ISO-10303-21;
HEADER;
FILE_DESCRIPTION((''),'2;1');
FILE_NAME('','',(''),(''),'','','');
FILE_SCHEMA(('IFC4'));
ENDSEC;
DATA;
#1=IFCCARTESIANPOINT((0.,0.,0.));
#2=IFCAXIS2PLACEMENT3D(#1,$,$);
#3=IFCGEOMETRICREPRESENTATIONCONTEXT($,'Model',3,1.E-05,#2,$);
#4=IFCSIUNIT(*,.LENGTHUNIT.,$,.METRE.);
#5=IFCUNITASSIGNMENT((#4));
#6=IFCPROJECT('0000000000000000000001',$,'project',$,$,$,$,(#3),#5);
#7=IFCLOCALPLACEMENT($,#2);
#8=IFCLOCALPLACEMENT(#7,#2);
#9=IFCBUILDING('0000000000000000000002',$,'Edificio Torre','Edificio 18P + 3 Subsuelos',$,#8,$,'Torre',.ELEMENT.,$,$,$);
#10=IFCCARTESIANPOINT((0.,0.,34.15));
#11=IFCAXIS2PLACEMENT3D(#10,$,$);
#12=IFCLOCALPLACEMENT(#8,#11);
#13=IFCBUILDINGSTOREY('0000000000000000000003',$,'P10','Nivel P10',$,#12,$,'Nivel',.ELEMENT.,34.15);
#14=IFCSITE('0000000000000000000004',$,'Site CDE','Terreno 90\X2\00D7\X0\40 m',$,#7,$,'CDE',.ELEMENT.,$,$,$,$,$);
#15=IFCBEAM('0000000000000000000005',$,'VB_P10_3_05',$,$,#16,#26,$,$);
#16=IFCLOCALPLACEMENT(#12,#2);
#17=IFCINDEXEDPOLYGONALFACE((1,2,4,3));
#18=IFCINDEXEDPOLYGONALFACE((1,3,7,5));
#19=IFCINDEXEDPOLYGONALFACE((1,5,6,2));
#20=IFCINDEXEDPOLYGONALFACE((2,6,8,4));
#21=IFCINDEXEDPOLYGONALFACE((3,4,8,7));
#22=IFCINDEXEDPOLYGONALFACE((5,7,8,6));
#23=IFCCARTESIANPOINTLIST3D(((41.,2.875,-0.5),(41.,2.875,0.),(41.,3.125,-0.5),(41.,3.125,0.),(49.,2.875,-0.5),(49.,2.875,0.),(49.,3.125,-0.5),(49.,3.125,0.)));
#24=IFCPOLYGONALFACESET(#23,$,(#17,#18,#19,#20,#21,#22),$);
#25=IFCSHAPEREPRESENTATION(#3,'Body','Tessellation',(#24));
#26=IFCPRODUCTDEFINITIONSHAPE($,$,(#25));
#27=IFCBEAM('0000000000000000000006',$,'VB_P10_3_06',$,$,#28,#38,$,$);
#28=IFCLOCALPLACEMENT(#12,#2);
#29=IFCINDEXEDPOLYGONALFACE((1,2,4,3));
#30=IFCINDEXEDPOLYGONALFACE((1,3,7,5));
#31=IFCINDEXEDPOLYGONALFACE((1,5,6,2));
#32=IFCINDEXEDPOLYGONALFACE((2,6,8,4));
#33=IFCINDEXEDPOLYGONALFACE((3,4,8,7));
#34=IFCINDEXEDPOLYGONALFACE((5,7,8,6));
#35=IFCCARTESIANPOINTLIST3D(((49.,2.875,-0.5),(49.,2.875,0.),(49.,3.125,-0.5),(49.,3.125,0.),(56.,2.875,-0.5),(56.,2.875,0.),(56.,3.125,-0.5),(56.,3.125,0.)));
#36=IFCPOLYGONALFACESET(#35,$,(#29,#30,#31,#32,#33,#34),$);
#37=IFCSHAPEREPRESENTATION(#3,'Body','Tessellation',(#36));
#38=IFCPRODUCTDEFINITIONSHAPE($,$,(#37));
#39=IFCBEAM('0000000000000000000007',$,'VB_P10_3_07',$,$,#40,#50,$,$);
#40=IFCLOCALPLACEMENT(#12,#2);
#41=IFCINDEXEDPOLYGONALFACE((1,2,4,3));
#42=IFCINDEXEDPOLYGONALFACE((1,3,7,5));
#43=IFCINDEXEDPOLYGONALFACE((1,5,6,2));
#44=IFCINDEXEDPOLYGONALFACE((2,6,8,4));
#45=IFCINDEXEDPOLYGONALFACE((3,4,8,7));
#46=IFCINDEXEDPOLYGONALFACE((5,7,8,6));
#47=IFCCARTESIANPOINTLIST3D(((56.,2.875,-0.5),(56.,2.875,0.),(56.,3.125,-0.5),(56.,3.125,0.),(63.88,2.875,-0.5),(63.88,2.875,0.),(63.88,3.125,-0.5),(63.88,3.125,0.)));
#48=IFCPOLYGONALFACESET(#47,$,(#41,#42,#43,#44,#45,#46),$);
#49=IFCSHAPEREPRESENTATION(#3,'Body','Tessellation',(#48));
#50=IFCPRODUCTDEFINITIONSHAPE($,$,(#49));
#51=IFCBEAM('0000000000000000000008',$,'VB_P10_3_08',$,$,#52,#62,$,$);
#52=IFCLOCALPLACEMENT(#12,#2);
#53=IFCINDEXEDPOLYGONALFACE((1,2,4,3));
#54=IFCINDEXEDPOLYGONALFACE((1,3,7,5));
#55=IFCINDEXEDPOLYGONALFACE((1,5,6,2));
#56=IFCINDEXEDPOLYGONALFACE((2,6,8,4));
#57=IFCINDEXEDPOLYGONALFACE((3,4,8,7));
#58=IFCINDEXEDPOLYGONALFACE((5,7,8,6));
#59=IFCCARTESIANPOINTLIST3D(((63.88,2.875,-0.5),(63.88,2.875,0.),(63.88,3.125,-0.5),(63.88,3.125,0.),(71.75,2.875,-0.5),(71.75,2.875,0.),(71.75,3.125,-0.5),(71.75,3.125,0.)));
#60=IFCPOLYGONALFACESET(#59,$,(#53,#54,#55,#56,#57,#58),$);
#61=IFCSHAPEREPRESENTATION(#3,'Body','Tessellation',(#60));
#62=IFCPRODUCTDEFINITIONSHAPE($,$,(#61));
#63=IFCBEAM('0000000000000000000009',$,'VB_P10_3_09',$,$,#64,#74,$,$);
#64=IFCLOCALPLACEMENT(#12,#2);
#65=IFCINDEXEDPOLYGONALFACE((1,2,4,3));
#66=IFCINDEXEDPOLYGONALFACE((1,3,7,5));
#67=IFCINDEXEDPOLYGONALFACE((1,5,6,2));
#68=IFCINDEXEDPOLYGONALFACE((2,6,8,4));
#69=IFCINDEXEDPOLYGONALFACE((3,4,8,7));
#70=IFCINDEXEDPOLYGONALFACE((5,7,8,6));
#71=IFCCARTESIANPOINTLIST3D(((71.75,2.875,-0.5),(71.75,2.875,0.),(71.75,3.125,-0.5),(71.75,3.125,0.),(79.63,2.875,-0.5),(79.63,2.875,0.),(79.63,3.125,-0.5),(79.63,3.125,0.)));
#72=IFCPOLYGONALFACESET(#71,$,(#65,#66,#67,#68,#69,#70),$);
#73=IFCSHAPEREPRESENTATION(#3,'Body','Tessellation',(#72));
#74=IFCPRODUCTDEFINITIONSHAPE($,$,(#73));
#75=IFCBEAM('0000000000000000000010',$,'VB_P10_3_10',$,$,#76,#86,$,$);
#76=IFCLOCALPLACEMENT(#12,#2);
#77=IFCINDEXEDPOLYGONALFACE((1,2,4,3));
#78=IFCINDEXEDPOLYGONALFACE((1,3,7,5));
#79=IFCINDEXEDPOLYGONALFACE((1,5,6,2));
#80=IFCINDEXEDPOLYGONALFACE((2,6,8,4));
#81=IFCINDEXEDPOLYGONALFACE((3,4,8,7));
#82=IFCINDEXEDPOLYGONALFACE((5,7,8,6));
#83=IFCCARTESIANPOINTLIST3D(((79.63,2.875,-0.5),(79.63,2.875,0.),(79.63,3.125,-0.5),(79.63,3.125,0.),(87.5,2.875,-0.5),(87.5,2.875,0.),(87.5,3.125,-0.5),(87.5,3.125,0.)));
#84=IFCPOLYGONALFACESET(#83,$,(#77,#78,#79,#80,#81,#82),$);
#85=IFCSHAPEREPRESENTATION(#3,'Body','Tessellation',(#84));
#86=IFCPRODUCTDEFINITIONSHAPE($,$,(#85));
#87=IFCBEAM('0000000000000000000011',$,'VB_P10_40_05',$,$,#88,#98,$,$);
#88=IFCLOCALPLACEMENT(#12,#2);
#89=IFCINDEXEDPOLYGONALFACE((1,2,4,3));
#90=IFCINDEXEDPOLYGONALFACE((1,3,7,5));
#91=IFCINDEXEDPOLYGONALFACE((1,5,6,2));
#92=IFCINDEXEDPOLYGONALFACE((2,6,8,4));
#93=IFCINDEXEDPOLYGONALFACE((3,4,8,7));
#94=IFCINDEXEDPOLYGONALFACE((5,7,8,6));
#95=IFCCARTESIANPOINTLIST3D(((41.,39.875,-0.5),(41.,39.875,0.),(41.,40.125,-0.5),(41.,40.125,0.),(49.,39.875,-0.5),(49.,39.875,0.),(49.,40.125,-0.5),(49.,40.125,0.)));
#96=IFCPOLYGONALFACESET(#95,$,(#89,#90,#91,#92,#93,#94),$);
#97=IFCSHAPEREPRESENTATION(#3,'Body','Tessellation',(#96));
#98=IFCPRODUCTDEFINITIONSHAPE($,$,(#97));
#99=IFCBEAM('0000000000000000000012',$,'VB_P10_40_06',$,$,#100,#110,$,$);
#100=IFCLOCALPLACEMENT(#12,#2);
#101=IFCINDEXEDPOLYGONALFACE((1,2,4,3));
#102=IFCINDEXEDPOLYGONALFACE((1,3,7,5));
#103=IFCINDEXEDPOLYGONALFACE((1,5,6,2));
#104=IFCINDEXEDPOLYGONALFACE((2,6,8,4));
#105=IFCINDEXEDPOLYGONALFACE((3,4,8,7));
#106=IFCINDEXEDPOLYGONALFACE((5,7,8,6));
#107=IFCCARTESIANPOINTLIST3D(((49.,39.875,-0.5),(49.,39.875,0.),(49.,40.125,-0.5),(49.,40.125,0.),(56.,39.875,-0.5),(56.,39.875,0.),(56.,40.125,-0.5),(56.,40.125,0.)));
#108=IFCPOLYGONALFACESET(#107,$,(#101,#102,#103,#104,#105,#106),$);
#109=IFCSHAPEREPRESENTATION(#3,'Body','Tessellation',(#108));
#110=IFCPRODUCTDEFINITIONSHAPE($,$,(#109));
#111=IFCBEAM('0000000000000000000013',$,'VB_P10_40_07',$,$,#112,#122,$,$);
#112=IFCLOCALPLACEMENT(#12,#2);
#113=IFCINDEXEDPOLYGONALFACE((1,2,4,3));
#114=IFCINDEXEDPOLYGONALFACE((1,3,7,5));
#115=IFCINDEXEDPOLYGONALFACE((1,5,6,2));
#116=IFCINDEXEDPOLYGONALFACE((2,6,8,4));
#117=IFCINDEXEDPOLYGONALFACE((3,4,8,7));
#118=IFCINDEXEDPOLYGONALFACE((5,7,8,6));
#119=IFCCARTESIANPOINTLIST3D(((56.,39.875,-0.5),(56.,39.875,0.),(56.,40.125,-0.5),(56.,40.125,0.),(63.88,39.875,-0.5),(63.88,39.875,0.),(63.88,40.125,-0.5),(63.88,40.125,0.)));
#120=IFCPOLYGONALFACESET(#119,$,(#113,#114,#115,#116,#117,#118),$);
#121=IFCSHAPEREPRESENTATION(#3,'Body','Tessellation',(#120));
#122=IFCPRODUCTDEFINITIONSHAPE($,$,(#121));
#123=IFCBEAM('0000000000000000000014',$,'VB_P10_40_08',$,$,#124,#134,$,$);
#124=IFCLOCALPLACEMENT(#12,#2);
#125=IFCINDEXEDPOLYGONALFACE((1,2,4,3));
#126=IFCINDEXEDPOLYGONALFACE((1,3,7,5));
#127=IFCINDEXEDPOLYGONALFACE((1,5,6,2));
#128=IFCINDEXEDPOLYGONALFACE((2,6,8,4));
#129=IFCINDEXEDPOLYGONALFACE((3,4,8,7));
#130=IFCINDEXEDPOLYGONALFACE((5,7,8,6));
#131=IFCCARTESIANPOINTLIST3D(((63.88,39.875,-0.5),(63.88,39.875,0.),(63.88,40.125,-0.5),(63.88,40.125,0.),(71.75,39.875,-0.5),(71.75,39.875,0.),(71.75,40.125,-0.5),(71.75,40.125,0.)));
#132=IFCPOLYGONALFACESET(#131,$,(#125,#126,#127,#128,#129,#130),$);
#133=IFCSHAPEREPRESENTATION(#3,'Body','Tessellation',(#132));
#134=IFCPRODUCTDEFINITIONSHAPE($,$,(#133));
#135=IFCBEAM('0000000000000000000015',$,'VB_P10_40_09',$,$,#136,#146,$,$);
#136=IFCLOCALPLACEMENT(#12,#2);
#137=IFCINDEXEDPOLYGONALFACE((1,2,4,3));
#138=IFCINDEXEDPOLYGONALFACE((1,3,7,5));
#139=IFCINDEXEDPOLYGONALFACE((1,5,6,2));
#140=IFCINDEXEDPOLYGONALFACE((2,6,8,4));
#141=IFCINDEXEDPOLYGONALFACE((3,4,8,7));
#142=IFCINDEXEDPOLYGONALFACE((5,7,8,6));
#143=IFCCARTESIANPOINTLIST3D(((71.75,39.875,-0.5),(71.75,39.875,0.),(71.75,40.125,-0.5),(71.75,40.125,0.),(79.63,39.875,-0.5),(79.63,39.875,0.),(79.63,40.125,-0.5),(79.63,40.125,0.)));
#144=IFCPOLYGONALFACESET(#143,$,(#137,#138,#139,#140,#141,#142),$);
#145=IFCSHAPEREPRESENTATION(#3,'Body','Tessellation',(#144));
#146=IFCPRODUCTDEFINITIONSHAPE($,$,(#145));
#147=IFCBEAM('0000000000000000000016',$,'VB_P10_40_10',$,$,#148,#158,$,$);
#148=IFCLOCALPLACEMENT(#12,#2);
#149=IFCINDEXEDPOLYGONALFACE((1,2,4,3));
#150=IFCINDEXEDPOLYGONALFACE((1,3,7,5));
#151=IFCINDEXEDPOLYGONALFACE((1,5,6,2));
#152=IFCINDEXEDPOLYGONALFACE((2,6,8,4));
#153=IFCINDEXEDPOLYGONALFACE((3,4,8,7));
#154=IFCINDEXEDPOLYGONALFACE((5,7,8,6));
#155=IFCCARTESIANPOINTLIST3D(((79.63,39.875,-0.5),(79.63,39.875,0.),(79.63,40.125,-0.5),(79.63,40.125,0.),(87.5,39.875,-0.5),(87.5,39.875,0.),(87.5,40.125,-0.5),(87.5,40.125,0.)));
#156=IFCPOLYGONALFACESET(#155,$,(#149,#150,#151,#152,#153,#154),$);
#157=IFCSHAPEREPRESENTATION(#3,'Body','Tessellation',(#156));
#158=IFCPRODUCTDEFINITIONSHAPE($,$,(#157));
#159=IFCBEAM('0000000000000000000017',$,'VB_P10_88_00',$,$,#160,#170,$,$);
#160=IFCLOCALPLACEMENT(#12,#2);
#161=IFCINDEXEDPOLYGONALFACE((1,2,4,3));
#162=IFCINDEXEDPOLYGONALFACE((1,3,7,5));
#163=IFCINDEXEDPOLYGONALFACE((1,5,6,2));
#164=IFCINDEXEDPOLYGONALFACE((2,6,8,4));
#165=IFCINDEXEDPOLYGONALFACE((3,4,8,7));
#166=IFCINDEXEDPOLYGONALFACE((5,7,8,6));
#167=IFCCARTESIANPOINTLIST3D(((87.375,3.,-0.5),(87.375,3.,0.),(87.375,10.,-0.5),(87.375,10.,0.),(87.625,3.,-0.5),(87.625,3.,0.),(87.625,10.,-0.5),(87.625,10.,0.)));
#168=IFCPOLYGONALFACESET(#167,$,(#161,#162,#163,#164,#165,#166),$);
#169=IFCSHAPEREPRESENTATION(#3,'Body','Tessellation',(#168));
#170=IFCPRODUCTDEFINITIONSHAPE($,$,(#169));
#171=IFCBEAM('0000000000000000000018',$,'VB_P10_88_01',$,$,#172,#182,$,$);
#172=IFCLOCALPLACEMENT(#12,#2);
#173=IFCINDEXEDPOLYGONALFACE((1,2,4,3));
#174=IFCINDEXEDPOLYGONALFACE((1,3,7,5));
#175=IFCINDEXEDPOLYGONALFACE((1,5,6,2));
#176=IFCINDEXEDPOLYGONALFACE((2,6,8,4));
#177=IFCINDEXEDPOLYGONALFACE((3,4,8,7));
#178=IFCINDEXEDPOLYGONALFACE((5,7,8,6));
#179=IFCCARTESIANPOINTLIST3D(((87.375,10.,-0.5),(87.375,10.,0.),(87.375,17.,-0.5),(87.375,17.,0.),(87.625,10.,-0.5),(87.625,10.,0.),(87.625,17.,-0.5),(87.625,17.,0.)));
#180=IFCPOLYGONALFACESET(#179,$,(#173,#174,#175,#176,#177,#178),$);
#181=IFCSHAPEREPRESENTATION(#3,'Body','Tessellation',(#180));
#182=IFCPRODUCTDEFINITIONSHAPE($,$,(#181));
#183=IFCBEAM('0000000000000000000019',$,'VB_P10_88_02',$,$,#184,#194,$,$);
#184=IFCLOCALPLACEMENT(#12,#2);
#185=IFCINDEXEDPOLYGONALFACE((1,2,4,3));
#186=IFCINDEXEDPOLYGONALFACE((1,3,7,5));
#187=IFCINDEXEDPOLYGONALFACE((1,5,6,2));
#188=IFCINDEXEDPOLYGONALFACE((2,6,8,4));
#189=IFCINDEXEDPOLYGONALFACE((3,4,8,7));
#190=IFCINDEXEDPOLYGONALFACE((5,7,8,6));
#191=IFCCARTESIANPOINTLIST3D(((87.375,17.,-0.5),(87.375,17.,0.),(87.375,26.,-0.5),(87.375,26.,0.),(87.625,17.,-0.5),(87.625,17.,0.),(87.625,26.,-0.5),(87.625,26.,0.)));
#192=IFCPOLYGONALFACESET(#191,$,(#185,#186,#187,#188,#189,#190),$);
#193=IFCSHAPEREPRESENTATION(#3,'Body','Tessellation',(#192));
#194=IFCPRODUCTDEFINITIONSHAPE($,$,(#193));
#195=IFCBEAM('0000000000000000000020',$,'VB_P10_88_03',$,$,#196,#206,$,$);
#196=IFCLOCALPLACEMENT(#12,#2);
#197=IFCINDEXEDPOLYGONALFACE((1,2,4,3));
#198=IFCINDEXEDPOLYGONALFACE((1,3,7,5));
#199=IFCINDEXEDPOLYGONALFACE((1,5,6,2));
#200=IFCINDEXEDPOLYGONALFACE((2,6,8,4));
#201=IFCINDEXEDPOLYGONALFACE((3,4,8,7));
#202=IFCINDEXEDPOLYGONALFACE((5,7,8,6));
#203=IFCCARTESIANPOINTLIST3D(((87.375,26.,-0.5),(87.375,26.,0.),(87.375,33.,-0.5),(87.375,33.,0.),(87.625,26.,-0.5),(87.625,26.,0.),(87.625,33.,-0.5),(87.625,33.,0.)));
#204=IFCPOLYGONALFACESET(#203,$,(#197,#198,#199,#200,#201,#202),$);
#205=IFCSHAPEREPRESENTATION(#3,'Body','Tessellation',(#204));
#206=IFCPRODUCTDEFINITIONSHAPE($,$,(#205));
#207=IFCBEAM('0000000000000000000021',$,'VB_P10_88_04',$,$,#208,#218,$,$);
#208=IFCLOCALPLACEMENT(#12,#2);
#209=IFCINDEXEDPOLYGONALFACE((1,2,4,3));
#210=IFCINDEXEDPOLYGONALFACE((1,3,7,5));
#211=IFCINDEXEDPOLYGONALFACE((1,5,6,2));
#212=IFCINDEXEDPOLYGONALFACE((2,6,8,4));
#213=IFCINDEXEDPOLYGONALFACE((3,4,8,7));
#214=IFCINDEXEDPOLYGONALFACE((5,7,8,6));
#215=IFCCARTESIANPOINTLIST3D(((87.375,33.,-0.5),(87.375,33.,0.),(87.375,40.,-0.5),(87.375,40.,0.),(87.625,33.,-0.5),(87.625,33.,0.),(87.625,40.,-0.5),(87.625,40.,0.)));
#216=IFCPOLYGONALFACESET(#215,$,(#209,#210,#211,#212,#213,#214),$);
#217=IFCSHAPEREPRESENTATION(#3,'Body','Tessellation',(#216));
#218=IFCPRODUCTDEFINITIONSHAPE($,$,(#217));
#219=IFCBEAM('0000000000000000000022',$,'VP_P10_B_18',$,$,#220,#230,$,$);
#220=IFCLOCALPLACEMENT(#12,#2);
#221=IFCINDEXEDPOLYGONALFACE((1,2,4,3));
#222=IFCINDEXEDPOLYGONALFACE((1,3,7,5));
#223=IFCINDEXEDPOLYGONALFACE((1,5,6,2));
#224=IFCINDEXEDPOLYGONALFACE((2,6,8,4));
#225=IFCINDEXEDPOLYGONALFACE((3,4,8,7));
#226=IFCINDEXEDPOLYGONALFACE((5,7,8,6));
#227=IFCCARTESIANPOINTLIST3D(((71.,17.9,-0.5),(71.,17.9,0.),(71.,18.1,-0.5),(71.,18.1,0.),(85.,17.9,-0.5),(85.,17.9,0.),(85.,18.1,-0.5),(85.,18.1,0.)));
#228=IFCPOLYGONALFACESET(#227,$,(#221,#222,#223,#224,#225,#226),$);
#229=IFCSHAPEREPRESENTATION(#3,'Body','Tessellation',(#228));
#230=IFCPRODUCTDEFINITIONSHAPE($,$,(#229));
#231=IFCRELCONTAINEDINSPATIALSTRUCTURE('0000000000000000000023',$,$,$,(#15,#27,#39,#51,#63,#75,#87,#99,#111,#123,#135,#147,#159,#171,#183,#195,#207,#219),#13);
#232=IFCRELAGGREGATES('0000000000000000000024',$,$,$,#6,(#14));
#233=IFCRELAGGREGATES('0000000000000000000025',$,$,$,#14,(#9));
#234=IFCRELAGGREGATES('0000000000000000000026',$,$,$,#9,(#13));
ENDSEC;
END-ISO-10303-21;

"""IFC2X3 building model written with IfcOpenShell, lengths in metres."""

from ifc_helpers import new_model, si_unit, frame, origin, origin_2d, place, context, project, spatial, rectangle, extrude, element, save


model = new_model("IFC2X3")

# Units and contexts
model_context = context("Model", 3, precision=1e-05, world=origin())
ifc_project = project(units=[si_unit("LENGTHUNIT", "METRE")], contexts=[model_context])

# Site, building, storey
site_placement = place(None, origin())
site = spatial("IfcSite", under=ifc_project, at=site_placement, Name="Site CDE", Description="Terreno 90×40 m", LongName="CDE", CompositionType="ELEMENT")
building_placement = place(site_placement, origin())
building = spatial("IfcBuilding", under=site, at=building_placement, Name="Edificio Torre", Description="Edificio 18P + 3 Subsuelos", LongName="Torre", CompositionType="ELEMENT")
storey_placement = place(building_placement, frame((0.0, 0.0, 34.15)))
storey = spatial("IfcBuildingStorey", under=building, at=storey_placement, Name="P10", Description="Nivel P10", LongName="Nivel", CompositionType="ELEMENT", Elevation=34.15)

# Beams
beam_1_placement = place(storey_placement, frame((45.0, 3.0, -0.5)))
element("IfcBeam", 1, at=beam_1_placement, inside=storey, Name="VB_P10_3_05", context=model_context, shape_type="SweptSolid", body=[
    extrude(rectangle(XDim=8.0, YDim=0.25, at=origin_2d()), origin(), (0.0, 0.0, 1.0), 0.5),
])
beam_2_placement = place(storey_placement, frame((52.5, 3.0, -0.5)))
element("IfcBeam", 2, at=beam_2_placement, inside=storey, Name="VB_P10_3_06", context=model_context, shape_type="SweptSolid", body=[
    extrude(rectangle(XDim=7.0, YDim=0.25, at=origin_2d()), origin(), (0.0, 0.0, 1.0), 0.5),
])
beam_3_placement = place(storey_placement, frame((59.94, 3.0, -0.5)))
element("IfcBeam", 3, at=beam_3_placement, inside=storey, Name="VB_P10_3_07", context=model_context, shape_type="SweptSolid", body=[
    extrude(rectangle(XDim=7.88, YDim=0.25, at=origin_2d()), origin(), (0.0, 0.0, 1.0), 0.5),
])
beam_4_placement = place(storey_placement, frame((67.815, 3.0, -0.5)))
element("IfcBeam", 4, at=beam_4_placement, inside=storey, Name="VB_P10_3_08", context=model_context, shape_type="SweptSolid", body=[
    extrude(rectangle(XDim=7.87, YDim=0.25, at=origin_2d()), origin(), (0.0, 0.0, 1.0), 0.5),
])
beam_5_placement = place(storey_placement, frame((75.69, 3.0, -0.5)))
element("IfcBeam", 5, at=beam_5_placement, inside=storey, Name="VB_P10_3_09", context=model_context, shape_type="SweptSolid", body=[
    extrude(rectangle(XDim=7.88, YDim=0.25, at=origin_2d()), origin(), (0.0, 0.0, 1.0), 0.5),
])
beam_6_placement = place(storey_placement, frame((83.565, 3.0, -0.5)))
element("IfcBeam", 6, at=beam_6_placement, inside=storey, Name="VB_P10_3_10", context=model_context, shape_type="SweptSolid", body=[
    extrude(rectangle(XDim=7.87, YDim=0.25, at=origin_2d()), origin(), (0.0, 0.0, 1.0), 0.5),
])
beam_7_placement = place(storey_placement, frame((45.0, 40.0, -0.5)))
element("IfcBeam", 7, at=beam_7_placement, inside=storey, Name="VB_P10_40_05", context=model_context, shape_type="SweptSolid", body=[
    extrude(rectangle(XDim=8.0, YDim=0.25, at=origin_2d()), origin(), (0.0, 0.0, 1.0), 0.5),
])
beam_8_placement = place(storey_placement, frame((52.5, 40.0, -0.5)))
element("IfcBeam", 8, at=beam_8_placement, inside=storey, Name="VB_P10_40_06", context=model_context, shape_type="SweptSolid", body=[
    extrude(rectangle(XDim=7.0, YDim=0.25, at=origin_2d()), origin(), (0.0, 0.0, 1.0), 0.5),
])
beam_9_placement = place(storey_placement, frame((59.94, 40.0, -0.5)))
element("IfcBeam", 9, at=beam_9_placement, inside=storey, Name="VB_P10_40_07", context=model_context, shape_type="SweptSolid", body=[
    extrude(rectangle(XDim=7.88, YDim=0.25, at=origin_2d()), origin(), (0.0, 0.0, 1.0), 0.5),
])
beam_10_placement = place(storey_placement, frame((67.815, 40.0, -0.5)))
element("IfcBeam", 10, at=beam_10_placement, inside=storey, Name="VB_P10_40_08", context=model_context, shape_type="SweptSolid", body=[
    extrude(rectangle(XDim=7.87, YDim=0.25, at=origin_2d()), origin(), (0.0, 0.0, 1.0), 0.5),
])
beam_11_placement = place(storey_placement, frame((75.69, 40.0, -0.5)))
element("IfcBeam", 11, at=beam_11_placement, inside=storey, Name="VB_P10_40_09", context=model_context, shape_type="SweptSolid", body=[
    extrude(rectangle(XDim=7.88, YDim=0.25, at=origin_2d()), origin(), (0.0, 0.0, 1.0), 0.5),
])
beam_12_placement = place(storey_placement, frame((83.565, 40.0, -0.5)))
element("IfcBeam", 12, at=beam_12_placement, inside=storey, Name="VB_P10_40_10", context=model_context, shape_type="SweptSolid", body=[
    extrude(rectangle(XDim=7.87, YDim=0.25, at=origin_2d()), origin(), (0.0, 0.0, 1.0), 0.5),
])
for number, where, name in (
    (13, (87.5, 6.5, -0.5), "VB_P10_88_00"),
    (14, (87.5, 13.5, -0.5), "VB_P10_88_01"),
):
    element("IfcBeam", number, at=place(storey_placement, frame(where)), inside=storey, Name=name, context=model_context, shape_type="SweptSolid", body=[
        extrude(rectangle(XDim=0.25, YDim=7.0, at=origin_2d()), origin(), (0.0, 0.0, 1.0), 0.5),
    ])
beam_13_placement = place(storey_placement, frame((87.5, 21.5, -0.5)))
element("IfcBeam", 15, at=beam_13_placement, inside=storey, Name="VB_P10_88_02", context=model_context, shape_type="SweptSolid", body=[
    extrude(rectangle(XDim=0.25, YDim=9.0, at=origin_2d()), origin(), (0.0, 0.0, 1.0), 0.5),
])
for number, where, name in (
    (16, (87.5, 29.5, -0.5), "VB_P10_88_03"),
    (17, (87.5, 36.5, -0.5), "VB_P10_88_04"),
):
    element("IfcBeam", number, at=place(storey_placement, frame(where)), inside=storey, Name=name, context=model_context, shape_type="SweptSolid", body=[
        extrude(rectangle(XDim=0.25, YDim=7.0, at=origin_2d()), origin(), (0.0, 0.0, 1.0), 0.5),
    ])
for number, where, name in (
    (18, (78.0, 18.0, -0.5), "VP_P10_B_18"),
):
    element("IfcBeam", number, at=place(storey_placement, frame(where)), inside=storey, Name=name, context=model_context, shape_type="SweptSolid", body=[
        extrude(rectangle(XDim=14.0, YDim=0.2, at=origin_2d()), origin(), (0.0, 0.0, 1.0), 0.5),
    ])

save(model, "model.ifc")
